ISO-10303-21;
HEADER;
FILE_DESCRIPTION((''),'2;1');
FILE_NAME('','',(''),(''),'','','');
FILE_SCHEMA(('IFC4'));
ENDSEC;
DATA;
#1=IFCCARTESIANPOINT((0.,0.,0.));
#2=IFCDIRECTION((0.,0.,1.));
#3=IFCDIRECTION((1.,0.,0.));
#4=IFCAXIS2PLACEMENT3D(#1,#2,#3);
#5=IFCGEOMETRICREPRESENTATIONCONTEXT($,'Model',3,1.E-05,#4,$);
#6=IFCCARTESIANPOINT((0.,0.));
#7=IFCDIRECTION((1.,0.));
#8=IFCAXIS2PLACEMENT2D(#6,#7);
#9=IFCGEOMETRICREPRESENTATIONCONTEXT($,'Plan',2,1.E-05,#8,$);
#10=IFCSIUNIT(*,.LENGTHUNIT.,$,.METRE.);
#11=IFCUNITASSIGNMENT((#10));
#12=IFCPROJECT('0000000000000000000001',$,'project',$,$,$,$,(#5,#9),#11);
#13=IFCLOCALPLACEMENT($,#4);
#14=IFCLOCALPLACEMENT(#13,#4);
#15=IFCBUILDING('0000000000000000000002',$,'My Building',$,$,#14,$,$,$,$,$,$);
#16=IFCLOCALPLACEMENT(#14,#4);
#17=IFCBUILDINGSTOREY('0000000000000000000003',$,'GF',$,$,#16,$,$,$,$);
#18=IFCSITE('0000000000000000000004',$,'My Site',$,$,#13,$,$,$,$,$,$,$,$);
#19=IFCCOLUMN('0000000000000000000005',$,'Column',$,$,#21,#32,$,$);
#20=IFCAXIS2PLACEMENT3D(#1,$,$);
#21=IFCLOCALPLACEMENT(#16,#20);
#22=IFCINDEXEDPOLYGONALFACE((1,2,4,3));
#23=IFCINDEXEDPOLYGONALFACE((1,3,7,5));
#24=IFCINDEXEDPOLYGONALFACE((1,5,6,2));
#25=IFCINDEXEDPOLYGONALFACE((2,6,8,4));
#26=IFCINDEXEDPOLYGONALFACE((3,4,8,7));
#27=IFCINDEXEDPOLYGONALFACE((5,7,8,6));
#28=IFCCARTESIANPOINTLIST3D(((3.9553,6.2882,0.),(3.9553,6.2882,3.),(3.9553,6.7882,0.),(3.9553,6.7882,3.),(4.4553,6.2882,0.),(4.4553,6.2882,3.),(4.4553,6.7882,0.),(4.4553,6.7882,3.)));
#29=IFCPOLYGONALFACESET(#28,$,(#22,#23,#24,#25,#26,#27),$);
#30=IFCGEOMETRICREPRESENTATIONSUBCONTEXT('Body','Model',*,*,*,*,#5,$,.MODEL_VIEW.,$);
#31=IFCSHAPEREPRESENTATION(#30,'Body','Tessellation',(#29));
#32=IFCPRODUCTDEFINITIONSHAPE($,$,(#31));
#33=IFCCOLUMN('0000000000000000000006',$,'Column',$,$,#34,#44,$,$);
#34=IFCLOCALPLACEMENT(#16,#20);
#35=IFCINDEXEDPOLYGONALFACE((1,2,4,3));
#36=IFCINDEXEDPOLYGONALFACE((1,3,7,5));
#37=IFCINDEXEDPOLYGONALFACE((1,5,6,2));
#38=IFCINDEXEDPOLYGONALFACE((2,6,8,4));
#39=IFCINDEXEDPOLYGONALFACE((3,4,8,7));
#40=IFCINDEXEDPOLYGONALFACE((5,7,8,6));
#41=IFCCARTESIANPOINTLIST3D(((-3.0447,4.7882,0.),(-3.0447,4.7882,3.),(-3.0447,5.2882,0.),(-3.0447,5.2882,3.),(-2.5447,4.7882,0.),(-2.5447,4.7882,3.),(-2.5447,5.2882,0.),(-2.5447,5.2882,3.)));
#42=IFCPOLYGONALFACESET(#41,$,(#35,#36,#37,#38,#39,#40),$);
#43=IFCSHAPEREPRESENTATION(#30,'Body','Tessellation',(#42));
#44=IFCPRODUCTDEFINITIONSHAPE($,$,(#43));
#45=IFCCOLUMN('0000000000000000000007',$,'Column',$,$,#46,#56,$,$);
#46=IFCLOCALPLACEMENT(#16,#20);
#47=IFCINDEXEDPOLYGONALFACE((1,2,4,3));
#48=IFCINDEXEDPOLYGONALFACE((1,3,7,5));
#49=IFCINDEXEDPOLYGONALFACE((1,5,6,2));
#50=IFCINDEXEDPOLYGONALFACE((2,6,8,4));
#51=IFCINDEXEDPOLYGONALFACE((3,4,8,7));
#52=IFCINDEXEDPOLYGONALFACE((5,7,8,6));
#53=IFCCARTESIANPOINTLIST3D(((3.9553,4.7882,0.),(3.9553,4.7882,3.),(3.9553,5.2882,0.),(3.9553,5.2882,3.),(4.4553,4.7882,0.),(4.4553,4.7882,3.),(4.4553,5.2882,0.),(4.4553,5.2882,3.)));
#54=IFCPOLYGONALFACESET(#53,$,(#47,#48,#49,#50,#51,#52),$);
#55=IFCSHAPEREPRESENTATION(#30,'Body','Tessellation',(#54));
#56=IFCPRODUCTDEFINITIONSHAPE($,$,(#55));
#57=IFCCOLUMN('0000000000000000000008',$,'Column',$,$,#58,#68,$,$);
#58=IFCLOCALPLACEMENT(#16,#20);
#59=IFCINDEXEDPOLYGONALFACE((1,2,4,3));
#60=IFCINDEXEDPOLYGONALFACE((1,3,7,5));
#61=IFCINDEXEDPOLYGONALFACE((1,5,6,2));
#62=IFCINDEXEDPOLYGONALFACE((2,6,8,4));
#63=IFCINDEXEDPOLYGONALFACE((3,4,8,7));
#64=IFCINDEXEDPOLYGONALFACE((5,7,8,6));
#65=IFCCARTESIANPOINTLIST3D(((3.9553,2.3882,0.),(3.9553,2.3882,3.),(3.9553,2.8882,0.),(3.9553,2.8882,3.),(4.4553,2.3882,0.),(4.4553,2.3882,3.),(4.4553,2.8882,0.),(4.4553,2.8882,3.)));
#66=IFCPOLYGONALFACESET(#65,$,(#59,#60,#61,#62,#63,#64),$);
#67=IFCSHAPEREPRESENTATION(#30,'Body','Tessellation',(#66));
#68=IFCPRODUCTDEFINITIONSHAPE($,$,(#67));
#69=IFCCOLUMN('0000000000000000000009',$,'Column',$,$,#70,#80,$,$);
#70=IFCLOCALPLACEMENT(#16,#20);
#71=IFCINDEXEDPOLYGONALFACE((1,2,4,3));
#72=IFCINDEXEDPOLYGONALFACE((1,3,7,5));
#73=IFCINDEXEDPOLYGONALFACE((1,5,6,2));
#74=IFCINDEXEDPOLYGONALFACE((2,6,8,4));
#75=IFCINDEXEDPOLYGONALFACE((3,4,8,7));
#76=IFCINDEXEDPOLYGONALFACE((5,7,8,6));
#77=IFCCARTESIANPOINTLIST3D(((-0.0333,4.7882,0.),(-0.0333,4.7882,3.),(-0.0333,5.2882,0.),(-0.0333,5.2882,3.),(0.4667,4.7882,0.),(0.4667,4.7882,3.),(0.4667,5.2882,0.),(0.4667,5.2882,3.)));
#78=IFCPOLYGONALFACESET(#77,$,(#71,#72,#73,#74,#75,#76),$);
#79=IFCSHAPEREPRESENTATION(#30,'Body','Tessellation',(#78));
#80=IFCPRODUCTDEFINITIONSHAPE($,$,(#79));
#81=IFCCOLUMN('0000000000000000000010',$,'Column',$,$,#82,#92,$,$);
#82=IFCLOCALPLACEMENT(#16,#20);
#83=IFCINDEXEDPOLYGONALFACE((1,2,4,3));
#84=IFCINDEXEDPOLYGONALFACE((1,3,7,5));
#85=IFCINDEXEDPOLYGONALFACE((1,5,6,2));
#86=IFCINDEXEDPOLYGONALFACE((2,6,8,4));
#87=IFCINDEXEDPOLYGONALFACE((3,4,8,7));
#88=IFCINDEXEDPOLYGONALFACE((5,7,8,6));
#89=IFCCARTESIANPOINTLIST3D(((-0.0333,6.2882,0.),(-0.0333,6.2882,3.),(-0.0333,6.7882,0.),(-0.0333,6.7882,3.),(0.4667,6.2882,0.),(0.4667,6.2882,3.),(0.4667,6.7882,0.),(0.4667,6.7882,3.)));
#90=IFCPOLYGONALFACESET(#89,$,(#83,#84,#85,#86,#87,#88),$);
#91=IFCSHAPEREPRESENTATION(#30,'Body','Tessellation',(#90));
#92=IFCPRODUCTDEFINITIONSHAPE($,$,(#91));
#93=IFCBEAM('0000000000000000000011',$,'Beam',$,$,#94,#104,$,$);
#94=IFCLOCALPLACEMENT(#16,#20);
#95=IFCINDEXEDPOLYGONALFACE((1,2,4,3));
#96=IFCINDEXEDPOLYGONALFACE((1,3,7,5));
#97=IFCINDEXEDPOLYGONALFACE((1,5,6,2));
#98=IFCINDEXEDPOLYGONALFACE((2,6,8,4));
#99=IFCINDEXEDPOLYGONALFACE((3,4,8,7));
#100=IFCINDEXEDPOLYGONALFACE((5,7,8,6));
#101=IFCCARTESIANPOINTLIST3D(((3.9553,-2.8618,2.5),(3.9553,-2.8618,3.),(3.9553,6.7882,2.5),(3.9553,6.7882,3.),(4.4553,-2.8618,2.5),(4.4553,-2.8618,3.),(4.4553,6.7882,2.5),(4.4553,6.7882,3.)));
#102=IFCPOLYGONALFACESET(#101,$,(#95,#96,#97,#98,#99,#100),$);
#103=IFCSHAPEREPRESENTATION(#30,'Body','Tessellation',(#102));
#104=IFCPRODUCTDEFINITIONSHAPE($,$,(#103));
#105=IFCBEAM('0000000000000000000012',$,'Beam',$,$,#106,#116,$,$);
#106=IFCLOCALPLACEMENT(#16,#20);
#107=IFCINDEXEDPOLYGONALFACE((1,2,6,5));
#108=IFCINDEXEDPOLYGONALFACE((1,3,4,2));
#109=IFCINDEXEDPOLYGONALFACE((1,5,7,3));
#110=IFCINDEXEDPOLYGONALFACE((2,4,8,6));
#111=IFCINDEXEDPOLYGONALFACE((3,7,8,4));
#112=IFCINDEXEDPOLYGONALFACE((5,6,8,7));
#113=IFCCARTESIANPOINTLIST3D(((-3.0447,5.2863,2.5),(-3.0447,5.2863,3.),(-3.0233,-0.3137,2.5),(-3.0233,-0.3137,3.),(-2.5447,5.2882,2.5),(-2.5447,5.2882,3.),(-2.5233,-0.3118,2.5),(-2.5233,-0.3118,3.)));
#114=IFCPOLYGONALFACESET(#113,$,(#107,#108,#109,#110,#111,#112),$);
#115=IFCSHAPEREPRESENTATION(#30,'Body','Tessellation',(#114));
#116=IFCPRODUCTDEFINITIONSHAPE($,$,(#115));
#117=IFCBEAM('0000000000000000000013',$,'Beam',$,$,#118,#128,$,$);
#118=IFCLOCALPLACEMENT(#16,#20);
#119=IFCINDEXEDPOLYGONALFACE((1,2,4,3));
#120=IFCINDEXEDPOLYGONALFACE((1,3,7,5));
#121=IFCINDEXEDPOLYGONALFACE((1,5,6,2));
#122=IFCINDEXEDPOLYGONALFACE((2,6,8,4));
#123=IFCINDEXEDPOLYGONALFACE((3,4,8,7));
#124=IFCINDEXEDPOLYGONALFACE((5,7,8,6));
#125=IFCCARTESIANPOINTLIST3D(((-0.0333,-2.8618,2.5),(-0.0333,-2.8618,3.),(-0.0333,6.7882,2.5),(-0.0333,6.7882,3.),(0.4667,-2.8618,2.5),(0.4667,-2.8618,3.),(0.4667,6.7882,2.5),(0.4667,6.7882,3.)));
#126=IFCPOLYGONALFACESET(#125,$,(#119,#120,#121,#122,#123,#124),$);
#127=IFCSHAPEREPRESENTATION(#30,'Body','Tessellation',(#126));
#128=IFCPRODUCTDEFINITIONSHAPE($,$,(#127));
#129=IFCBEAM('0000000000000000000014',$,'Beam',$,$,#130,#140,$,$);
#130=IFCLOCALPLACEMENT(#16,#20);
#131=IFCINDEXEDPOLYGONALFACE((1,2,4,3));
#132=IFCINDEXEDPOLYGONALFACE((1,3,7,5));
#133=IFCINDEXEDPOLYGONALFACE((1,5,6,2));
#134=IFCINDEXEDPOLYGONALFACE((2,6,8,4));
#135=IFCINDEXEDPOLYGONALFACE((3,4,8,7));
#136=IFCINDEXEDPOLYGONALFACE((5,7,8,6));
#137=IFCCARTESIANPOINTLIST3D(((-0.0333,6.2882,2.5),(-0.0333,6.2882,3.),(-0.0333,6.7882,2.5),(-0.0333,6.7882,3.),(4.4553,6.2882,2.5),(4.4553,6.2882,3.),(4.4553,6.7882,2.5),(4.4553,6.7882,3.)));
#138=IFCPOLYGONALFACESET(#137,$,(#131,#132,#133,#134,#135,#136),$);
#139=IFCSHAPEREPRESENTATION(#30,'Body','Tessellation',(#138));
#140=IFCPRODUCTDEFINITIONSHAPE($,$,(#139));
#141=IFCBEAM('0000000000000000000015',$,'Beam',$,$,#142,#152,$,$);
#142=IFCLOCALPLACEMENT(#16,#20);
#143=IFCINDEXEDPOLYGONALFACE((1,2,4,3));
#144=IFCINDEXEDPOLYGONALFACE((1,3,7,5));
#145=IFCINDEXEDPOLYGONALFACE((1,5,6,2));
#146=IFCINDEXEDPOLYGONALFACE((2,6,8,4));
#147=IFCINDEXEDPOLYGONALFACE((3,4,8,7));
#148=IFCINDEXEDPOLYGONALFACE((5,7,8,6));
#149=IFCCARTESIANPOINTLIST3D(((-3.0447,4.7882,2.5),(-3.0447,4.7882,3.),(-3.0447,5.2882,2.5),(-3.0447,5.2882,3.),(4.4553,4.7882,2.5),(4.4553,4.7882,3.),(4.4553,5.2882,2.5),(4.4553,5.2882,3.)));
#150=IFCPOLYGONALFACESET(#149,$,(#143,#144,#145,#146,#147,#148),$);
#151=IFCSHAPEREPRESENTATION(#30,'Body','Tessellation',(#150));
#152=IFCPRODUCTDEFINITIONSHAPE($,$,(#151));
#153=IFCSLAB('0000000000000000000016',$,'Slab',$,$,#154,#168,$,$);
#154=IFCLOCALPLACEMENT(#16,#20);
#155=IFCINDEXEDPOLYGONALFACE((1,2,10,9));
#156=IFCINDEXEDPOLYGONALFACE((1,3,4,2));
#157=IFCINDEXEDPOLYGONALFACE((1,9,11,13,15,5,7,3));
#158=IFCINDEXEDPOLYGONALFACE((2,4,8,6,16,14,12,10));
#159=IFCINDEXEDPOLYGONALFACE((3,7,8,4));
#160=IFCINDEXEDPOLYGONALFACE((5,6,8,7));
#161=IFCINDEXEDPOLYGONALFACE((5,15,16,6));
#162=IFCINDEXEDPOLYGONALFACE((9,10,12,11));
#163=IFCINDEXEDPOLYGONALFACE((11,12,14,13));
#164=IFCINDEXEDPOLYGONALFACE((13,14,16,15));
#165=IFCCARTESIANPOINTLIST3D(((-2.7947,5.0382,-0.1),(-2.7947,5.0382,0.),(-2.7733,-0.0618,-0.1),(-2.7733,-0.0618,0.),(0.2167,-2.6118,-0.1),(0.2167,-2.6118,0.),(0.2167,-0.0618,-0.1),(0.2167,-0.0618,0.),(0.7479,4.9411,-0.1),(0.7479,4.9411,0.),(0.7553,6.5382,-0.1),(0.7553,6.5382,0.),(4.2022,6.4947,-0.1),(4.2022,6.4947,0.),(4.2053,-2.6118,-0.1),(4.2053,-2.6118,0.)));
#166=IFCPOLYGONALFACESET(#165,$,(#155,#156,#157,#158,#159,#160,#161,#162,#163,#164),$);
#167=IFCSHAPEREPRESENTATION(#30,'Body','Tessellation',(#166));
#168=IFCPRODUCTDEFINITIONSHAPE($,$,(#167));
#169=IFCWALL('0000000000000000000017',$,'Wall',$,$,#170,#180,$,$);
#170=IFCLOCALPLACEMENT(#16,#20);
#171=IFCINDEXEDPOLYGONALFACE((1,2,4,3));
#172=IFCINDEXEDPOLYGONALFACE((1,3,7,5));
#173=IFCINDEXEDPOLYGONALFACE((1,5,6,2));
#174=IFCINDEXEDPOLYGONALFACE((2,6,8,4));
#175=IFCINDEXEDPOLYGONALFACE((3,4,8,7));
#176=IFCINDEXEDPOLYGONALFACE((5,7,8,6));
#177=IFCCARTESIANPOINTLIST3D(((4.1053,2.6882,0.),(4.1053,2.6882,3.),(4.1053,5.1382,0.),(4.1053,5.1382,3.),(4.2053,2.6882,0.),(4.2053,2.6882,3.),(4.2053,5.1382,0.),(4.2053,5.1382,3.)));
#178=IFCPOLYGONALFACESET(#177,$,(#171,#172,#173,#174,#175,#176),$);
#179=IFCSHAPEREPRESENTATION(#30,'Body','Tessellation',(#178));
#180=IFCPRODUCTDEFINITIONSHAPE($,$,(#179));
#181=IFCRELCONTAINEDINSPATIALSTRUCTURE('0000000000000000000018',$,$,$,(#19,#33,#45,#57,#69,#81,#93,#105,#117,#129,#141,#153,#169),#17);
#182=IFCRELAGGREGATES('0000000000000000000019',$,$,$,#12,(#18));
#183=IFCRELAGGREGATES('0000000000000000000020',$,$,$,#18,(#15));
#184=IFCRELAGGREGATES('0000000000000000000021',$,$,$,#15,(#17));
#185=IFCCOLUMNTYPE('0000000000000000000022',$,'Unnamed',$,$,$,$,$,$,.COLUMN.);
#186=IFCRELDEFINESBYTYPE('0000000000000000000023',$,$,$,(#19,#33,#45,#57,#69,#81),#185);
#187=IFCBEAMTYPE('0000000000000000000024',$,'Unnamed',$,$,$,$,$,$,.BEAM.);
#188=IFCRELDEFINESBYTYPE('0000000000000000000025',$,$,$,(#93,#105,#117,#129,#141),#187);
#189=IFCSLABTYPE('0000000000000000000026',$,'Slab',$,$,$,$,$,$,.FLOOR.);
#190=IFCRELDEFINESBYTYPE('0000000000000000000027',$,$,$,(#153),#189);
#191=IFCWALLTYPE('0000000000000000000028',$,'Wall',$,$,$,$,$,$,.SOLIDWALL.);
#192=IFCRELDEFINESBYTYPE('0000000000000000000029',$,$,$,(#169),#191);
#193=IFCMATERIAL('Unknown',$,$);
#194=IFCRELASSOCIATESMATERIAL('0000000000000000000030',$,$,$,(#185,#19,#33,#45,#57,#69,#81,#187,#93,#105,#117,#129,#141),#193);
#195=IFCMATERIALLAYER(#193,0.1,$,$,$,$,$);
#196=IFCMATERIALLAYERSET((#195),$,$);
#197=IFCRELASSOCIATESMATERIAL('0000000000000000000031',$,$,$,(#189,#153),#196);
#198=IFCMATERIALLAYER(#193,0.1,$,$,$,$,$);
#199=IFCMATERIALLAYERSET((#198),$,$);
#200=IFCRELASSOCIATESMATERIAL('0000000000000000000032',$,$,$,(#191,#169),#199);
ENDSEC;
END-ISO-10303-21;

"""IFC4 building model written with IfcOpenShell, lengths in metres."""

from ifc_helpers import new_model, si_unit, frame, origin_with_axes, origin_2d_with_axis, place, context, subcontext, project, spatial, line, indexed_curve, rectangle, outline, extrude, material, layer, layer_set, layer_usage, material_profile, profile_set, profile_usage, type_object, element, save


model = new_model("IFC4")

# Units and contexts
model_context = context("Model", 3, precision=1e-05, world=origin_with_axes())
plan_context = context("Plan", 2, precision=1e-05, world=origin_2d_with_axis())
body_context_1 = subcontext(model_context, "Body", "Model", "MODEL_VIEW")
ifc_project = project(units=[si_unit("LENGTHUNIT", "METRE")], contexts=[model_context, plan_context])

# Site, building, storey
site_placement = place(None, origin_with_axes())
site = spatial("IfcSite", under=ifc_project, at=site_placement, Name="My Site")
building_placement = place(site_placement, origin_with_axes())
building = spatial("IfcBuilding", under=site, at=building_placement, Name="My Building")
storey_placement = place(building_placement, origin_with_axes())
storey = spatial("IfcBuildingStorey", under=building, at=storey_placement, Name="GF")

# Columns
ifc_material_1 = material(Name="Unknown")
ifc_material_profile_1 = material_profile(ifc_material_1, rectangle(XDim=0.5, YDim=0.5))
ifc_profile_set_1 = profile_set([ifc_material_profile_1])
ifc_profile_usage_1 = profile_usage(ifc_profile_set_1, cardinal=5)
column_type = type_object("IfcColumnType", Name="Unnamed", PredefinedType="COLUMN", material=ifc_profile_set_1)
column_1_placement = place(storey_placement, frame((4.2053, 6.5382, 0.0), z_axis=(0.0, 0.0, 1.0), x_axis=(1.0, 0.0, 0.0)))
element("IfcColumn", 1, at=column_1_placement, inside=storey, type_object=column_type, material=ifc_profile_usage_1, Name="Column", context=body_context_1, shape_type="SweptSolid", body=[
    extrude(rectangle(XDim=0.5, YDim=0.5), origin_with_axes(), (0.0, 0.0, 1.0), 3.0),
])
ifc_profile_usage_2 = profile_usage(ifc_profile_set_1, cardinal=5)
column_2_placement = place(storey_placement, frame((-2.7947, 5.0382, 0.0), z_axis=(0.0, 0.0, 1.0), x_axis=(1.0, 0.0, 0.0)))
element("IfcColumn", 2, at=column_2_placement, inside=storey, type_object=column_type, material=ifc_profile_usage_2, Name="Column", context=body_context_1, shape_type="SweptSolid", body=[
    extrude(rectangle(XDim=0.5, YDim=0.5), origin_with_axes(), (0.0, 0.0, 1.0), 3.0),
])
ifc_profile_usage_3 = profile_usage(ifc_profile_set_1, cardinal=5)
column_3_placement = place(storey_placement, frame((4.2053, 5.0382, 0.0), z_axis=(0.0, 0.0, 1.0), x_axis=(1.0, 0.0, 0.0)))
element("IfcColumn", 3, at=column_3_placement, inside=storey, type_object=column_type, material=ifc_profile_usage_3, Name="Column", context=body_context_1, shape_type="SweptSolid", body=[
    extrude(rectangle(XDim=0.5, YDim=0.5), origin_with_axes(), (0.0, 0.0, 1.0), 3.0),
])
ifc_profile_usage_4 = profile_usage(ifc_profile_set_1, cardinal=5)
column_4_placement = place(storey_placement, frame((4.2053, 2.6382, 0.0), z_axis=(0.0, 0.0, 1.0), x_axis=(1.0, 0.0, 0.0)))
element("IfcColumn", 4, at=column_4_placement, inside=storey, type_object=column_type, material=ifc_profile_usage_4, Name="Column", context=body_context_1, shape_type="SweptSolid", body=[
    extrude(rectangle(XDim=0.5, YDim=0.5), origin_with_axes(), (0.0, 0.0, 1.0), 3.0),
])
ifc_profile_usage_5 = profile_usage(ifc_profile_set_1, cardinal=5)
column_5_placement = place(storey_placement, frame((0.2167, 5.0382, 0.0), z_axis=(0.0, 0.0, 1.0), x_axis=(1.0, 0.0, 0.0)))
element("IfcColumn", 5, at=column_5_placement, inside=storey, type_object=column_type, material=ifc_profile_usage_5, Name="Column", context=body_context_1, shape_type="SweptSolid", body=[
    extrude(rectangle(XDim=0.5, YDim=0.5), origin_with_axes(), (0.0, 0.0, 1.0), 3.0),
])
ifc_profile_usage_6 = profile_usage(ifc_profile_set_1, cardinal=5)
column_6_placement = place(storey_placement, frame((0.2167, 6.5382, 0.0), z_axis=(0.0, 0.0, 1.0), x_axis=(1.0, 0.0, 0.0)))
element("IfcColumn", 6, at=column_6_placement, inside=storey, type_object=column_type, material=ifc_profile_usage_6, Name="Column", context=body_context_1, shape_type="SweptSolid", body=[
    extrude(rectangle(XDim=0.5, YDim=0.5), origin_with_axes(), (0.0, 0.0, 1.0), 3.0),
])

# Beams
ifc_material_profile_2 = material_profile(ifc_material_1, rectangle(XDim=0.5, YDim=0.5))
ifc_profile_set_2 = profile_set([ifc_material_profile_2])
ifc_profile_usage_7 = profile_usage(ifc_profile_set_2, cardinal=7)
beam_type = type_object("IfcBeamType", Name="Unnamed", PredefinedType="BEAM", material=ifc_profile_set_2)
beam_1_placement = place(storey_placement, frame((4.4553, 6.7882, 3.0), z_axis=(0.0, -1.0, 0.0), x_axis=(1.0, 0.0, 0.0)))
element("IfcBeam", 7, at=beam_1_placement, inside=storey, type_object=beam_type, material=ifc_profile_usage_7, Name="Beam", context=body_context_1, shape_type="SweptSolid", body=[
    extrude(rectangle(XDim=0.5, YDim=0.5), frame((-0.25, -0.25, 0.0), z_axis=(0.0, 0.0, 1.0), x_axis=(1.0, 0.0, 0.0)), (0.0, 0.0, 1.0), 9.65),
])
ifc_profile_usage_8 = profile_usage(ifc_profile_set_2, cardinal=7)
beam_2_placement = place(storey_placement, frame((-2.5447, 5.2882, 3.0), z_axis=(0.003815, -0.999993, 0.0), x_axis=(0.999993, 0.003815, 0.0)))
element("IfcBeam", 8, at=beam_2_placement, inside=storey, type_object=beam_type, material=ifc_profile_usage_8, Name="Beam", context=body_context_1, shape_type="SweptSolid", body=[
    extrude(rectangle(XDim=0.5, YDim=0.5), frame((-0.25, -0.25, 0.0), z_axis=(0.0, 0.0, 1.0), x_axis=(1.0, 0.0, 0.0)), (0.0, 0.0, 1.0), 5.6),
])
ifc_profile_usage_9 = profile_usage(ifc_profile_set_2, cardinal=7)
beam_3_placement = place(storey_placement, frame((0.4667, 6.7882, 3.0), z_axis=(0.0, -1.0, 0.0), x_axis=(1.0, 0.0, 0.0)))
element("IfcBeam", 9, at=beam_3_placement, inside=storey, type_object=beam_type, material=ifc_profile_usage_9, Name="Beam", context=body_context_1, shape_type="SweptSolid", body=[
    extrude(rectangle(XDim=0.5, YDim=0.5), frame((-0.25, -0.25, 0.0), z_axis=(0.0, 0.0, 1.0), x_axis=(1.0, 0.0, 0.0)), (0.0, 0.0, 1.0), 9.65),
])
ifc_profile_usage_10 = profile_usage(ifc_profile_set_2, cardinal=7)
beam_4_placement = place(storey_placement, frame((4.4553, 6.2882, 3.0), z_axis=(-1.0, 0.0, 0.0), x_axis=(0.0, -1.0, 0.0)))
element("IfcBeam", 10, at=beam_4_placement, inside=storey, type_object=beam_type, material=ifc_profile_usage_10, Name="Beam", context=body_context_1, shape_type="SweptSolid", body=[
    extrude(rectangle(XDim=0.5, YDim=0.5), frame((-0.25, -0.25, 0.0), z_axis=(0.0, 0.0, 1.0), x_axis=(1.0, 0.0, 0.0)), (0.0, 0.0, 1.0), 4.4886),
])
ifc_profile_usage_11 = profile_usage(ifc_profile_set_2, cardinal=7)
beam_5_placement = place(storey_placement, frame((4.4553, 4.7882, 3.0), z_axis=(-1.0, 0.0, 0.0), x_axis=(0.0, -1.0, 0.0)))
element("IfcBeam", 11, at=beam_5_placement, inside=storey, type_object=beam_type, material=ifc_profile_usage_11, Name="Beam", context=body_context_1, shape_type="SweptSolid", body=[
    extrude(rectangle(XDim=0.5, YDim=0.5), frame((-0.25, -0.25, 0.0), z_axis=(0.0, 0.0, 1.0), x_axis=(1.0, 0.0, 0.0)), (0.0, 0.0, 1.0), 7.5),
])

# Slab
ifc_layer_1 = layer(ifc_material_1, 0.1)
ifc_layer_set_1 = layer_set([ifc_layer_1])
ifc_layer_usage_1 = layer_usage(ifc_layer_set_1, "AXIS3", "POSITIVE", -0.1)
slab_type = type_object("IfcSlabType", Name="Slab", PredefinedType="FLOOR", material=ifc_layer_set_1)
slab_placement = place(storey_placement, frame((4.2022, 6.4947, 0.0), z_axis=(0.0, 0.0, 1.0), x_axis=(1.0, 0.0, 0.0)))
element("IfcSlab", 12, at=slab_placement, inside=storey, type_object=slab_type, material=ifc_layer_usage_1, Name="Slab", context=body_context_1, shape_type="SweptSolid", body=[
    extrude(outline(indexed_curve([(0.0031, -9.1065), (-3.9855, -9.1065), (-3.9855, -6.5565), (-6.9755, -6.5565), (-6.9969, -1.4565), (-3.4543, -1.5535), (-3.4469, 0.0435), (0.0, 0.0), (0.0031, -9.1065)])), frame((0.0, 0.0, -0.1), z_axis=(0.0, 0.0, 1.0), x_axis=(1.0, 0.0, 0.0)), (0.0, 0.0, 1.0), 0.1),
])

# Wall
ifc_layer_2 = layer(ifc_material_1, 0.1)
ifc_layer_set_2 = layer_set([ifc_layer_2])
ifc_layer_usage_2 = layer_usage(ifc_layer_set_2, "AXIS2", "POSITIVE", 0.0)
wall_type = type_object("IfcWallType", Name="Wall", PredefinedType="SOLIDWALL", material=ifc_layer_set_2)
wall_1_placement = place(storey_placement, frame((4.2053, 2.6882, 0.0), z_axis=(0.0, 0.0, 1.0), x_axis=(0.0, 1.0, 0.0)))
element("IfcWall", 13, at=wall_1_placement, inside=storey, type_object=wall_type, material=ifc_layer_usage_2, Name="Wall", context=body_context_1, shape_type="SweptSolid", body=[
    extrude(outline(indexed_curve([(0.0, 0.0), (0.0, 0.1), (2.45, 0.1), (2.45, 0.0)], segments=[line(1, 2, 3, 4, 1)])), origin_with_axes(), (0.0, 0.0, 1.0), 3.0),
])

save(model, "model.ifc")
